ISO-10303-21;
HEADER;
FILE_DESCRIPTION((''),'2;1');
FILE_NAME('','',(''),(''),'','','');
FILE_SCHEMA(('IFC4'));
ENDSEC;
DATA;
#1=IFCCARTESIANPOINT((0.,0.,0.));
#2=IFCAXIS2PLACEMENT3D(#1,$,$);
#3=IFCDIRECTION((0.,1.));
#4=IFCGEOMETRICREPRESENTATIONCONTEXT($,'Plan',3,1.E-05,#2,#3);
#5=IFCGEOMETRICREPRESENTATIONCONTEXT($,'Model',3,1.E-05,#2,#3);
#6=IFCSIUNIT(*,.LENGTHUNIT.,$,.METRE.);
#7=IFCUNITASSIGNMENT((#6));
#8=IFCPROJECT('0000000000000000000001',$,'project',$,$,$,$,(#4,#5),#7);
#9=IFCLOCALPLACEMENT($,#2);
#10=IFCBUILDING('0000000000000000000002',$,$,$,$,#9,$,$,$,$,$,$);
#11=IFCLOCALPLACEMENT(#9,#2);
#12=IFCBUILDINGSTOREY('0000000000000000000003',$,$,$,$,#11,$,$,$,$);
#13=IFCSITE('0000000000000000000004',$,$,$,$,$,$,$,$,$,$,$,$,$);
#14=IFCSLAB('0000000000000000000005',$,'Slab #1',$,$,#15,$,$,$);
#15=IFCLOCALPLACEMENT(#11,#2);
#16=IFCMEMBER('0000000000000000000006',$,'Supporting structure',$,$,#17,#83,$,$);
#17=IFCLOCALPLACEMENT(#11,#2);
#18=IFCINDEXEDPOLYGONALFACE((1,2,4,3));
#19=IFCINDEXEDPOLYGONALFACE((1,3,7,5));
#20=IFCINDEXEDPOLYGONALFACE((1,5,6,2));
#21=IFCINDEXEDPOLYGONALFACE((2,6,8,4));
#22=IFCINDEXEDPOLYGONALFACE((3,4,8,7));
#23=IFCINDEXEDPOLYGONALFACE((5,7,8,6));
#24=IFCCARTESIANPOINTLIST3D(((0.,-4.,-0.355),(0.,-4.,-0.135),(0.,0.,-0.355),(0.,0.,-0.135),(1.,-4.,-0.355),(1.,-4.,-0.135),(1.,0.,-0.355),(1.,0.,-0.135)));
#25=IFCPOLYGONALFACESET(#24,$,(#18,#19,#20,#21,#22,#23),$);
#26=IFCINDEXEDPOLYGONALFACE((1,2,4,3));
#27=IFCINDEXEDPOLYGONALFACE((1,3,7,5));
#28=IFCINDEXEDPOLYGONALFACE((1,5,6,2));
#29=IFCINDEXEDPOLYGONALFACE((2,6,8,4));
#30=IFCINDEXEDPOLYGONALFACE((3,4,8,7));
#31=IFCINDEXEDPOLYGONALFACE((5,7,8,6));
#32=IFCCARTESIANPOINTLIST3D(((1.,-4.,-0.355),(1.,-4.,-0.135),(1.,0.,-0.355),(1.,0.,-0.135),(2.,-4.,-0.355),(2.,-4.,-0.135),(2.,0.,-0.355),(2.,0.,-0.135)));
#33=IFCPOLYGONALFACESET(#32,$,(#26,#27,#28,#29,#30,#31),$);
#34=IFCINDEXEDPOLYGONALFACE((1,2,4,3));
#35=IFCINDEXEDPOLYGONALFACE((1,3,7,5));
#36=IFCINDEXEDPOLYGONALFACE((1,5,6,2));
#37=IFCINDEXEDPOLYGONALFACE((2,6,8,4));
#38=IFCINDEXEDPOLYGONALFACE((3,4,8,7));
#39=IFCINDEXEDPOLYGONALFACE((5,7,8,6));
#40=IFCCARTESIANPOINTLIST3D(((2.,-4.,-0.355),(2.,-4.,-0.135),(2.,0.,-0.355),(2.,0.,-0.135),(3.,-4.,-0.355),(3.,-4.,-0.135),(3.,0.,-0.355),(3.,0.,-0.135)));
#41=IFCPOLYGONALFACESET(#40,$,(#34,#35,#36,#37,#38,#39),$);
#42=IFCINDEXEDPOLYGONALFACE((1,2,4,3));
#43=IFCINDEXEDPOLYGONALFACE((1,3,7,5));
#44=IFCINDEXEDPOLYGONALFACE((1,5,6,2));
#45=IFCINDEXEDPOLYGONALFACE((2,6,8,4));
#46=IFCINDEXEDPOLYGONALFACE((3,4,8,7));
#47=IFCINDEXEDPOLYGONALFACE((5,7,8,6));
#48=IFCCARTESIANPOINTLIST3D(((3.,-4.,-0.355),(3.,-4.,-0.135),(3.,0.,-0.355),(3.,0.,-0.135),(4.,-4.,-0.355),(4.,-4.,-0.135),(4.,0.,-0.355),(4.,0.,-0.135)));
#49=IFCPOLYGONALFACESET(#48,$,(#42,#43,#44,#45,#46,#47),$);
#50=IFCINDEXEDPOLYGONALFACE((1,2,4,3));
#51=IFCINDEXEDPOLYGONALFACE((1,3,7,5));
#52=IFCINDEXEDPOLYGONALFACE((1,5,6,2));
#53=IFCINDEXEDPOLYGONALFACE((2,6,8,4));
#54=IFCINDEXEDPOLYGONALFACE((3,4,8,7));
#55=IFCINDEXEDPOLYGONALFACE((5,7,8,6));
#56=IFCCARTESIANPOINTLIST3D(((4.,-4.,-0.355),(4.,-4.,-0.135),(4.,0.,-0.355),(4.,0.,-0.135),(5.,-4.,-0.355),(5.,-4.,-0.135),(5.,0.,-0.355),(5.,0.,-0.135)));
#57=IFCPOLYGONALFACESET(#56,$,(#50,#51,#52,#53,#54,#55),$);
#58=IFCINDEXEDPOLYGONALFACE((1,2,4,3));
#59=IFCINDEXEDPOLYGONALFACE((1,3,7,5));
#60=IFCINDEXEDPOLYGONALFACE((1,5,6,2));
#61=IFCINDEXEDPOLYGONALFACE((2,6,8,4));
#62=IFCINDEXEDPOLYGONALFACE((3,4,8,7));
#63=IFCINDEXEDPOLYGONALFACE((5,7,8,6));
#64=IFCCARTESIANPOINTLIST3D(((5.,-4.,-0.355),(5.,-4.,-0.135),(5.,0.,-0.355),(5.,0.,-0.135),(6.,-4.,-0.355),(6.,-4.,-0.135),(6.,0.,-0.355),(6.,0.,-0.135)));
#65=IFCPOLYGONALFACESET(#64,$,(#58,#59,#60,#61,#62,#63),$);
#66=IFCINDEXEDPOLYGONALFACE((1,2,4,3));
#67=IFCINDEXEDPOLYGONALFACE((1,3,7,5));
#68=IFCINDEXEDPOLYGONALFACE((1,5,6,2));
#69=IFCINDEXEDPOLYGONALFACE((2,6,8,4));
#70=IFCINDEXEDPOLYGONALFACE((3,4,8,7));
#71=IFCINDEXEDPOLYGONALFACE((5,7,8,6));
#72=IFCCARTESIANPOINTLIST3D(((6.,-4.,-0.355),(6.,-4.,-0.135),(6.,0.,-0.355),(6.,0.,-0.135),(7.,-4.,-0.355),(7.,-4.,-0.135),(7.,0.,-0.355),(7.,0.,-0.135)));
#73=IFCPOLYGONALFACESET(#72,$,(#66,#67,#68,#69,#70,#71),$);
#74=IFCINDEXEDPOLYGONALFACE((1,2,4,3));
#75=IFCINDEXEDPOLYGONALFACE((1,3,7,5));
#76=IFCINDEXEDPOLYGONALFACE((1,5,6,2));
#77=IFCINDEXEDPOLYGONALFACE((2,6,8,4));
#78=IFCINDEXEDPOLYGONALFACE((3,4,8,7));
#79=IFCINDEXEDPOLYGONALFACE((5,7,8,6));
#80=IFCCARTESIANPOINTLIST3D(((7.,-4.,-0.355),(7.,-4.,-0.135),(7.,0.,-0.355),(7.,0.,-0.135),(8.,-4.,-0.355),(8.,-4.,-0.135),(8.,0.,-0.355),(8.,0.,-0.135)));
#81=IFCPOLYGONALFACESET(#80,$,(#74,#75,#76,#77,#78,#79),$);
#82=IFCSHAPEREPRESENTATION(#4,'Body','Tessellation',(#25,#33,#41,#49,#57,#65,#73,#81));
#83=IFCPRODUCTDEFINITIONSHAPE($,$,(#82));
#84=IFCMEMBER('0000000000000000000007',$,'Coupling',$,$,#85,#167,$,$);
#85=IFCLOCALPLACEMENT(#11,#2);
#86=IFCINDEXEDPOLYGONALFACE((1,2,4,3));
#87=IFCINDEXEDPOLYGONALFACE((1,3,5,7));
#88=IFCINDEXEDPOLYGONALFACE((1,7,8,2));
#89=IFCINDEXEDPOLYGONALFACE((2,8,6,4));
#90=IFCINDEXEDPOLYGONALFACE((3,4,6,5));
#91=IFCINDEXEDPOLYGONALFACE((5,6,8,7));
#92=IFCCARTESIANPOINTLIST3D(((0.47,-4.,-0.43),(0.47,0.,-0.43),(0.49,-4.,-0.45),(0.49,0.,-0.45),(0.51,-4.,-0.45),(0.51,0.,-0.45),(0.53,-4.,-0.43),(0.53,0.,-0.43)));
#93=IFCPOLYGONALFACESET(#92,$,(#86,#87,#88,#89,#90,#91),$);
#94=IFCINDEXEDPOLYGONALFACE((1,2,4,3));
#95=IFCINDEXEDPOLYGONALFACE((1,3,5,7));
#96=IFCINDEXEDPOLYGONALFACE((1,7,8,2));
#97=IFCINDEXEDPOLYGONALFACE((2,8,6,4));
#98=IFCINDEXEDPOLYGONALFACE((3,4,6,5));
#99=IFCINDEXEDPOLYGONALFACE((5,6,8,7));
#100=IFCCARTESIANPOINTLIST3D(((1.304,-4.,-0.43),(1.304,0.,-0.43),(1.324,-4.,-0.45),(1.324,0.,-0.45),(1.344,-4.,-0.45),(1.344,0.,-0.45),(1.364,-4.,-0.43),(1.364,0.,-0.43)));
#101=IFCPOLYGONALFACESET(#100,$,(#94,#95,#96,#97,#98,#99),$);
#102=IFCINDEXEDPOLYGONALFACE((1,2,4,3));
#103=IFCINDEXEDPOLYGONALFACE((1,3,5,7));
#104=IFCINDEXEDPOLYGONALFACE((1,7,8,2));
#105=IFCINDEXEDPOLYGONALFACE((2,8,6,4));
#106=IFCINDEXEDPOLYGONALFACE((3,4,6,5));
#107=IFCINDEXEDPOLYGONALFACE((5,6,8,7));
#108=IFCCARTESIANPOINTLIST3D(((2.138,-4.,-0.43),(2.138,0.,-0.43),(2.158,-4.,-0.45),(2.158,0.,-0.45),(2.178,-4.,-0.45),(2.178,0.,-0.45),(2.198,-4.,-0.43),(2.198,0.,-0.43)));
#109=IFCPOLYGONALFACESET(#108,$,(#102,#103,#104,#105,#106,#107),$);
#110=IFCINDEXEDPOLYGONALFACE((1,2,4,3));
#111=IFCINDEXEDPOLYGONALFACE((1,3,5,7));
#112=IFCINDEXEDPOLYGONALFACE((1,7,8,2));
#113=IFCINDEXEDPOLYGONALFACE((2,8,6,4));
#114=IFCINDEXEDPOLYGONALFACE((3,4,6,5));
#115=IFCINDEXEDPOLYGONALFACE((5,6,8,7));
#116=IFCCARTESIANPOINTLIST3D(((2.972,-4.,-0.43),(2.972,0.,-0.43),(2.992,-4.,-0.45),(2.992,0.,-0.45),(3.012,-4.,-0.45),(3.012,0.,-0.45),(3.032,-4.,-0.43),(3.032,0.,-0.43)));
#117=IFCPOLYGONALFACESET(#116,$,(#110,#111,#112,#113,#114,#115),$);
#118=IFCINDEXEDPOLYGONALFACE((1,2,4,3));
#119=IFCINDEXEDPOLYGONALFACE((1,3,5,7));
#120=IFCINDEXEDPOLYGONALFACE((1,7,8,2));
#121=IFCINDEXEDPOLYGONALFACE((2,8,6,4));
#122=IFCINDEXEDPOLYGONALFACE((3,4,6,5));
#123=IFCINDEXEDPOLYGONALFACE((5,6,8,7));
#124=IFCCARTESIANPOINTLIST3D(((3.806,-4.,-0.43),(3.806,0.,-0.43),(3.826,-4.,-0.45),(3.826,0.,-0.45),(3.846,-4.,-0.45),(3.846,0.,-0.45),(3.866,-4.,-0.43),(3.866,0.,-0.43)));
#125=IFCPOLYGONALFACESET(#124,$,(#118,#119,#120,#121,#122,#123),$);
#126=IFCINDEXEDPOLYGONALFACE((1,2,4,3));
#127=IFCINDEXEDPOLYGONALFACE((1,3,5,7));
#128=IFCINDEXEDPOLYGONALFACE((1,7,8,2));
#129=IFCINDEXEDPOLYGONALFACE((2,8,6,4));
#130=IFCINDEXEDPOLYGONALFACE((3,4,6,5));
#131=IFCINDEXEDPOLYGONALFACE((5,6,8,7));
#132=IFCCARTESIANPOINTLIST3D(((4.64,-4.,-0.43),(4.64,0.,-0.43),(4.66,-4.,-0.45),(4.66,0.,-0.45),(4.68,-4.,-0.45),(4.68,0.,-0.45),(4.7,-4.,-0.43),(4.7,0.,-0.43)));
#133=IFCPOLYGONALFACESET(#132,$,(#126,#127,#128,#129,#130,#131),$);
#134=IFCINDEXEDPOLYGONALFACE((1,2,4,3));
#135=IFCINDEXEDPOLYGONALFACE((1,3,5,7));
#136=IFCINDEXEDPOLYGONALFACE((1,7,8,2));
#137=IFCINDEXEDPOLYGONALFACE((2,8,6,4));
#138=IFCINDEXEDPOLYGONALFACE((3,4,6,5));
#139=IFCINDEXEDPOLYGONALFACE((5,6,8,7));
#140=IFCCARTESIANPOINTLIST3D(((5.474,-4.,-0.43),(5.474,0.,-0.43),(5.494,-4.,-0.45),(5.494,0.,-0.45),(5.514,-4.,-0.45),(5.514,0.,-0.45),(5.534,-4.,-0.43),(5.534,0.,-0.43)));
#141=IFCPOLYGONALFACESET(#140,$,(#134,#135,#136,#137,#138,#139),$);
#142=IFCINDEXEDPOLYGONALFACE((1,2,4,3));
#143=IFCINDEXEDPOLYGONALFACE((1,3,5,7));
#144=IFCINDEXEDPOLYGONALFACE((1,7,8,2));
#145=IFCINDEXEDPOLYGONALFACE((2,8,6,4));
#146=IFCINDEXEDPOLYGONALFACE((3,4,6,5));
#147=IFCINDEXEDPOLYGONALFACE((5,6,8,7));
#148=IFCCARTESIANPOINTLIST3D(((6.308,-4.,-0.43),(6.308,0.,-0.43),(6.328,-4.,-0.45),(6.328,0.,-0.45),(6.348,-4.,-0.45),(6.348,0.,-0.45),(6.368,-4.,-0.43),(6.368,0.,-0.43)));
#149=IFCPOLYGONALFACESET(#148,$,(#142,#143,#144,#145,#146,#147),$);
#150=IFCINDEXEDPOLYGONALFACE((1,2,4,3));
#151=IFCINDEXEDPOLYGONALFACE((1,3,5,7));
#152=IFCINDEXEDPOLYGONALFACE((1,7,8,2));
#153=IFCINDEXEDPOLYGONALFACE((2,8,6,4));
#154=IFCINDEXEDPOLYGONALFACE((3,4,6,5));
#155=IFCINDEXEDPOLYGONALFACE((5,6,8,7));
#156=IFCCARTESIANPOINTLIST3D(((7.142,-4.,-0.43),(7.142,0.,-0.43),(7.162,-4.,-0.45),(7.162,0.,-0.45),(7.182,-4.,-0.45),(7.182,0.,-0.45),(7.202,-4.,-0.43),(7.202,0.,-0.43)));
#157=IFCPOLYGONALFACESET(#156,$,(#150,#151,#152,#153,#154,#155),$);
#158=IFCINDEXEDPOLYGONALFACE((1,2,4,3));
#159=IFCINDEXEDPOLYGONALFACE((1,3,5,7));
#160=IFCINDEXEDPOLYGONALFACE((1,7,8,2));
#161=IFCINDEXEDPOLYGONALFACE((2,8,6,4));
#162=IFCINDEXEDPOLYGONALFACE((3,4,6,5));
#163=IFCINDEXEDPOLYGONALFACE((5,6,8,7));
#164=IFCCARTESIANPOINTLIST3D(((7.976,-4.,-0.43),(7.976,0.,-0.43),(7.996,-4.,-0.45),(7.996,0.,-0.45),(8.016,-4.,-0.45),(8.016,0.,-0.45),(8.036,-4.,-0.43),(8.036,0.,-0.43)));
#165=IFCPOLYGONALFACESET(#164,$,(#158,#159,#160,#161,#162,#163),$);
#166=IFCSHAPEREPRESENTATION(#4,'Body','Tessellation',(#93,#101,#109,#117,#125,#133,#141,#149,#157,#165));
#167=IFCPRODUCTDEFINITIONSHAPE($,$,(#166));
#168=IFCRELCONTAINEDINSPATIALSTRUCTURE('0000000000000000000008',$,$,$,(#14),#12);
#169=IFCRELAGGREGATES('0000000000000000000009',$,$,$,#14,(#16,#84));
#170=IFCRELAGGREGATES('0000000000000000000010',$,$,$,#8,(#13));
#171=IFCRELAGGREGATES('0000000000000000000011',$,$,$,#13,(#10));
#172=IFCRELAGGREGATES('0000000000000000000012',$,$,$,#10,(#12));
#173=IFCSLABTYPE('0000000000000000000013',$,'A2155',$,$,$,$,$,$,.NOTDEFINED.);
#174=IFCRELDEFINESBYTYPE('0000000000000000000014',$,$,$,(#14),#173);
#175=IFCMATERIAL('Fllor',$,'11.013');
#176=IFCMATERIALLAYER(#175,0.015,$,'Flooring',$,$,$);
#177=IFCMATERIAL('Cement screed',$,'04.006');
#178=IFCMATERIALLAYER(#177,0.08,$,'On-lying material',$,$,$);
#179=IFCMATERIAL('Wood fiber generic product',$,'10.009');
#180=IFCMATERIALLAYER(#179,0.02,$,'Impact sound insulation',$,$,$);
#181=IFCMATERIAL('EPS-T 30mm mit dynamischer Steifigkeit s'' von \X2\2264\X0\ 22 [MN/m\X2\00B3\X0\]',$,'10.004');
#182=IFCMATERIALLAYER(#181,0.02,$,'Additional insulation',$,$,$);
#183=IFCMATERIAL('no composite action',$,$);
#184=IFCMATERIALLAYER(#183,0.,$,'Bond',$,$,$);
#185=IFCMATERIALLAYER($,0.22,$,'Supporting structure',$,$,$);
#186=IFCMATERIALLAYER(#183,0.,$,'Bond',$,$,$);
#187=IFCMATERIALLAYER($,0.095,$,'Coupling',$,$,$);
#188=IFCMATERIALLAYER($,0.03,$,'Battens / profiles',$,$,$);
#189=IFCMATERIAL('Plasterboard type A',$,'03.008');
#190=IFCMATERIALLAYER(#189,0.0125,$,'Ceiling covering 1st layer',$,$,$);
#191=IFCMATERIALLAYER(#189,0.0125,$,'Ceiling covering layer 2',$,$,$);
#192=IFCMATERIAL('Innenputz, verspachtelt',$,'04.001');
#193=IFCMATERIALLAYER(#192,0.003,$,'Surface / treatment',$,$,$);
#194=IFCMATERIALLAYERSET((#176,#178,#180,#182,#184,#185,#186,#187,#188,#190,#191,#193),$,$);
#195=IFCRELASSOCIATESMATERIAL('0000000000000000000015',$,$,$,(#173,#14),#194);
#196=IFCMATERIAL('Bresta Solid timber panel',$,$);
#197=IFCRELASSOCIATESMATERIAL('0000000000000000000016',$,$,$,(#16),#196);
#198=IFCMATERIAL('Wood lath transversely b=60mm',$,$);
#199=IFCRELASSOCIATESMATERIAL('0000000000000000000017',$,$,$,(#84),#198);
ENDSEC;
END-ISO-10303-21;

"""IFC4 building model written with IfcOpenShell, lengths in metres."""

from ifc_helpers import new_model, si_unit, direction, frame, frame_2d, origin, place, context, project, spatial, polyline, rectangle, outline, extrude, material, layer, layer_set, type_object, element, aggregate, save


model = new_model("IFC4")

# Units and contexts
plan_context = context("Plan", 3, precision=1e-05, world=origin(), true_north=direction((0.0, 1.0)))
model_context = context("Model", 3, precision=1e-05, world=origin(), true_north=direction((0.0, 1.0)))
ifc_project = project(units=[si_unit("LENGTHUNIT", "METRE")], contexts=[plan_context, model_context])

# Site, building, storey
site = spatial("IfcSite", under=ifc_project)
building_placement = place(None, origin())
building = spatial("IfcBuilding", under=site, at=building_placement)
storey_placement = place(building_placement, origin())
storey = spatial("IfcBuildingStorey", under=building, at=storey_placement)

# Slab, members
ifc_material_1 = material(Name="Fllor", Category="11.013")
ifc_layer_1 = layer(ifc_material_1, 0.015, Name="Flooring")
ifc_material_2 = material(Name="Cement screed", Category="04.006")
ifc_layer_2 = layer(ifc_material_2, 0.08, Name="On-lying material")
ifc_material_3 = material(Name="Wood fiber generic product", Category="10.009")
ifc_layer_3 = layer(ifc_material_3, 0.02, Name="Impact sound insulation")
ifc_material_4 = material(Name="EPS-T 30mm mit dynamischer Steifigkeit s' von ≤ 22 [MN/m³]", Category="10.004")
ifc_layer_4 = layer(ifc_material_4, 0.02, Name="Additional insulation")
ifc_material_5 = material(Name="no composite action")
ifc_layer_5 = layer(ifc_material_5, 0.0, Name="Bond")
ifc_layer_6 = layer(None, 0.22, Name="Supporting structure")
ifc_layer_7 = layer(ifc_material_5, 0.0, Name="Bond")
ifc_layer_8 = layer(None, 0.095, Name="Coupling")
ifc_layer_9 = layer(None, 0.03, Name="Battens / profiles")
ifc_material_6 = material(Name="Plasterboard type A", Category="03.008")
ifc_layer_10 = layer(ifc_material_6, 0.0125, Name="Ceiling covering 1st layer")
ifc_layer_11 = layer(ifc_material_6, 0.0125, Name="Ceiling covering layer 2")
ifc_material_7 = material(Name="Innenputz, verspachtelt", Category="04.001")
ifc_layer_12 = layer(ifc_material_7, 0.003, Name="Surface / treatment")
ifc_layer_set = layer_set([ifc_layer_1, ifc_layer_2, ifc_layer_3, ifc_layer_4, ifc_layer_5, ifc_layer_6, ifc_layer_7, ifc_layer_8, ifc_layer_9, ifc_layer_10, ifc_layer_11, ifc_layer_12])
slab_type = type_object("IfcSlabType", Name="A2155", PredefinedType="NOTDEFINED", material=ifc_layer_set)
slab_placement = place(None, frame((0.0, 0.0, 0.0), z_axis=(0.0, 0.0, -1.0), x_axis=(1.0, 0.0, 0.0)))
slab = element("IfcSlab", 1, at=slab_placement, inside=storey, type_object=slab_type, material=ifc_layer_set, Name="Slab #1")
ifc_material_8 = material(Name="Bresta Solid timber panel")
member_1_placement = place(slab_placement, origin())
member_1 = element("IfcMember", 2, at=member_1_placement, material=ifc_material_8, Name="Supporting structure", context=plan_context, shape_type="SweptSolid", body=[
    extrude(rectangle(XDim=1.0, YDim=0.22, at=frame_2d((0.5, 0.11), x_axis=(1.0, 0.0))), frame((0.0, 4.0, 0.135), z_axis=(0.0, -1.0, 0.0), x_axis=(1.0, 0.0, 0.0)), (0.0, 0.0, 1.0), 4.0),
    extrude(rectangle(XDim=1.0, YDim=0.22, at=frame_2d((0.5, 0.11), x_axis=(1.0, 0.0))), frame((1.0, 4.0, 0.135), z_axis=(0.0, -1.0, 0.0), x_axis=(1.0, 0.0, 0.0)), (0.0, 0.0, 1.0), 4.0),
    extrude(rectangle(XDim=1.0, YDim=0.22, at=frame_2d((0.5, 0.11), x_axis=(1.0, 0.0))), frame((2.0, 4.0, 0.135), z_axis=(0.0, -1.0, 0.0), x_axis=(1.0, 0.0, 0.0)), (0.0, 0.0, 1.0), 4.0),
    extrude(rectangle(XDim=1.0, YDim=0.22, at=frame_2d((0.5, 0.11), x_axis=(1.0, 0.0))), frame((3.0, 4.0, 0.135), z_axis=(0.0, -1.0, 0.0), x_axis=(1.0, 0.0, 0.0)), (0.0, 0.0, 1.0), 4.0),
    extrude(rectangle(XDim=1.0, YDim=0.22, at=frame_2d((0.5, 0.11), x_axis=(1.0, 0.0))), frame((4.0, 4.0, 0.135), z_axis=(0.0, -1.0, 0.0), x_axis=(1.0, 0.0, 0.0)), (0.0, 0.0, 1.0), 4.0),
    extrude(rectangle(XDim=1.0, YDim=0.22, at=frame_2d((0.5, 0.11), x_axis=(1.0, 0.0))), frame((5.0, 4.0, 0.135), z_axis=(0.0, -1.0, 0.0), x_axis=(1.0, 0.0, 0.0)), (0.0, 0.0, 1.0), 4.0),
    extrude(rectangle(XDim=1.0, YDim=0.22, at=frame_2d((0.5, 0.11), x_axis=(1.0, 0.0))), frame((6.0, 4.0, 0.135), z_axis=(0.0, -1.0, 0.0), x_axis=(1.0, 0.0, 0.0)), (0.0, 0.0, 1.0), 4.0),
    extrude(rectangle(XDim=1.0, YDim=0.22, at=frame_2d((0.5, 0.11), x_axis=(1.0, 0.0))), frame((7.0, 4.0, 0.135), z_axis=(0.0, -1.0, 0.0), x_axis=(1.0, 0.0, 0.0)), (0.0, 0.0, 1.0), 4.0),
])
ifc_material_9 = material(Name="Wood lath transversely b=60mm")
member_2_placement = place(slab_placement, origin())
member_2 = element("IfcMember", 3, at=member_2_placement, material=ifc_material_9, Name="Coupling", context=plan_context, shape_type="SweptSolid", body=[
    extrude(outline(polyline([(0.0, 0.0), (0.06, 0.0), (0.04, 0.02), (0.02, 0.02), (0.0, 0.0)])), frame((0.47, 4.0, 0.43), z_axis=(0.0, -1.0, 0.0), x_axis=(1.0, 0.0, 0.0)), (0.0, 0.0, 1.0), 4.0),
    extrude(outline(polyline([(0.0, 0.0), (0.06, 0.0), (0.04, 0.02), (0.02, 0.02), (0.0, 0.0)])), frame((1.304, 4.0, 0.43), z_axis=(0.0, -1.0, 0.0), x_axis=(1.0, 0.0, 0.0)), (0.0, 0.0, 1.0), 4.0),
    extrude(outline(polyline([(0.0, 0.0), (0.06, 0.0), (0.04, 0.02), (0.02, 0.02), (0.0, 0.0)])), frame((2.138, 4.0, 0.43), z_axis=(0.0, -1.0, 0.0), x_axis=(1.0, 0.0, 0.0)), (0.0, 0.0, 1.0), 4.0),
    extrude(outline(polyline([(0.0, 0.0), (0.06, 0.0), (0.04, 0.02), (0.02, 0.02), (0.0, 0.0)])), frame((2.972, 4.0, 0.43), z_axis=(0.0, -1.0, 0.0), x_axis=(1.0, 0.0, 0.0)), (0.0, 0.0, 1.0), 4.0),
    extrude(outline(polyline([(0.0, 0.0), (0.06, 0.0), (0.04, 0.02), (0.02, 0.02), (0.0, 0.0)])), frame((3.806, 4.0, 0.43), z_axis=(0.0, -1.0, 0.0), x_axis=(1.0, 0.0, 0.0)), (0.0, 0.0, 1.0), 4.0),
    extrude(outline(polyline([(0.0, 0.0), (0.06, 0.0), (0.04, 0.02), (0.02, 0.02), (0.0, 0.0)])), frame((4.64, 4.0, 0.43), z_axis=(0.0, -1.0, 0.0), x_axis=(1.0, 0.0, 0.0)), (0.0, 0.0, 1.0), 4.0),
    extrude(outline(polyline([(0.0, 0.0), (0.06, 0.0), (0.04, 0.02), (0.02, 0.02), (0.0, 0.0)])), frame((5.474, 4.0, 0.43), z_axis=(0.0, -1.0, 0.0), x_axis=(1.0, 0.0, 0.0)), (0.0, 0.0, 1.0), 4.0),
    extrude(outline(polyline([(0.0, 0.0), (0.06, 0.0), (0.04, 0.02), (0.02, 0.02), (0.0, 0.0)])), frame((6.308, 4.0, 0.43), z_axis=(0.0, -1.0, 0.0), x_axis=(1.0, 0.0, 0.0)), (0.0, 0.0, 1.0), 4.0),
    extrude(outline(polyline([(0.0, 0.0), (0.06, 0.0), (0.04, 0.02), (0.02, 0.02), (0.0, 0.0)])), frame((7.142, 4.0, 0.43), z_axis=(0.0, -1.0, 0.0), x_axis=(1.0, 0.0, 0.0)), (0.0, 0.0, 1.0), 4.0),
    extrude(outline(polyline([(0.0, 0.0), (0.06, 0.0), (0.04, 0.02), (0.02, 0.02), (0.0, 0.0)])), frame((7.976, 4.0, 0.43), z_axis=(0.0, -1.0, 0.0), x_axis=(1.0, 0.0, 0.0)), (0.0, 0.0, 1.0), 4.0),
])
aggregate(slab, [member_1, member_2])

save(model, "model.ifc")
